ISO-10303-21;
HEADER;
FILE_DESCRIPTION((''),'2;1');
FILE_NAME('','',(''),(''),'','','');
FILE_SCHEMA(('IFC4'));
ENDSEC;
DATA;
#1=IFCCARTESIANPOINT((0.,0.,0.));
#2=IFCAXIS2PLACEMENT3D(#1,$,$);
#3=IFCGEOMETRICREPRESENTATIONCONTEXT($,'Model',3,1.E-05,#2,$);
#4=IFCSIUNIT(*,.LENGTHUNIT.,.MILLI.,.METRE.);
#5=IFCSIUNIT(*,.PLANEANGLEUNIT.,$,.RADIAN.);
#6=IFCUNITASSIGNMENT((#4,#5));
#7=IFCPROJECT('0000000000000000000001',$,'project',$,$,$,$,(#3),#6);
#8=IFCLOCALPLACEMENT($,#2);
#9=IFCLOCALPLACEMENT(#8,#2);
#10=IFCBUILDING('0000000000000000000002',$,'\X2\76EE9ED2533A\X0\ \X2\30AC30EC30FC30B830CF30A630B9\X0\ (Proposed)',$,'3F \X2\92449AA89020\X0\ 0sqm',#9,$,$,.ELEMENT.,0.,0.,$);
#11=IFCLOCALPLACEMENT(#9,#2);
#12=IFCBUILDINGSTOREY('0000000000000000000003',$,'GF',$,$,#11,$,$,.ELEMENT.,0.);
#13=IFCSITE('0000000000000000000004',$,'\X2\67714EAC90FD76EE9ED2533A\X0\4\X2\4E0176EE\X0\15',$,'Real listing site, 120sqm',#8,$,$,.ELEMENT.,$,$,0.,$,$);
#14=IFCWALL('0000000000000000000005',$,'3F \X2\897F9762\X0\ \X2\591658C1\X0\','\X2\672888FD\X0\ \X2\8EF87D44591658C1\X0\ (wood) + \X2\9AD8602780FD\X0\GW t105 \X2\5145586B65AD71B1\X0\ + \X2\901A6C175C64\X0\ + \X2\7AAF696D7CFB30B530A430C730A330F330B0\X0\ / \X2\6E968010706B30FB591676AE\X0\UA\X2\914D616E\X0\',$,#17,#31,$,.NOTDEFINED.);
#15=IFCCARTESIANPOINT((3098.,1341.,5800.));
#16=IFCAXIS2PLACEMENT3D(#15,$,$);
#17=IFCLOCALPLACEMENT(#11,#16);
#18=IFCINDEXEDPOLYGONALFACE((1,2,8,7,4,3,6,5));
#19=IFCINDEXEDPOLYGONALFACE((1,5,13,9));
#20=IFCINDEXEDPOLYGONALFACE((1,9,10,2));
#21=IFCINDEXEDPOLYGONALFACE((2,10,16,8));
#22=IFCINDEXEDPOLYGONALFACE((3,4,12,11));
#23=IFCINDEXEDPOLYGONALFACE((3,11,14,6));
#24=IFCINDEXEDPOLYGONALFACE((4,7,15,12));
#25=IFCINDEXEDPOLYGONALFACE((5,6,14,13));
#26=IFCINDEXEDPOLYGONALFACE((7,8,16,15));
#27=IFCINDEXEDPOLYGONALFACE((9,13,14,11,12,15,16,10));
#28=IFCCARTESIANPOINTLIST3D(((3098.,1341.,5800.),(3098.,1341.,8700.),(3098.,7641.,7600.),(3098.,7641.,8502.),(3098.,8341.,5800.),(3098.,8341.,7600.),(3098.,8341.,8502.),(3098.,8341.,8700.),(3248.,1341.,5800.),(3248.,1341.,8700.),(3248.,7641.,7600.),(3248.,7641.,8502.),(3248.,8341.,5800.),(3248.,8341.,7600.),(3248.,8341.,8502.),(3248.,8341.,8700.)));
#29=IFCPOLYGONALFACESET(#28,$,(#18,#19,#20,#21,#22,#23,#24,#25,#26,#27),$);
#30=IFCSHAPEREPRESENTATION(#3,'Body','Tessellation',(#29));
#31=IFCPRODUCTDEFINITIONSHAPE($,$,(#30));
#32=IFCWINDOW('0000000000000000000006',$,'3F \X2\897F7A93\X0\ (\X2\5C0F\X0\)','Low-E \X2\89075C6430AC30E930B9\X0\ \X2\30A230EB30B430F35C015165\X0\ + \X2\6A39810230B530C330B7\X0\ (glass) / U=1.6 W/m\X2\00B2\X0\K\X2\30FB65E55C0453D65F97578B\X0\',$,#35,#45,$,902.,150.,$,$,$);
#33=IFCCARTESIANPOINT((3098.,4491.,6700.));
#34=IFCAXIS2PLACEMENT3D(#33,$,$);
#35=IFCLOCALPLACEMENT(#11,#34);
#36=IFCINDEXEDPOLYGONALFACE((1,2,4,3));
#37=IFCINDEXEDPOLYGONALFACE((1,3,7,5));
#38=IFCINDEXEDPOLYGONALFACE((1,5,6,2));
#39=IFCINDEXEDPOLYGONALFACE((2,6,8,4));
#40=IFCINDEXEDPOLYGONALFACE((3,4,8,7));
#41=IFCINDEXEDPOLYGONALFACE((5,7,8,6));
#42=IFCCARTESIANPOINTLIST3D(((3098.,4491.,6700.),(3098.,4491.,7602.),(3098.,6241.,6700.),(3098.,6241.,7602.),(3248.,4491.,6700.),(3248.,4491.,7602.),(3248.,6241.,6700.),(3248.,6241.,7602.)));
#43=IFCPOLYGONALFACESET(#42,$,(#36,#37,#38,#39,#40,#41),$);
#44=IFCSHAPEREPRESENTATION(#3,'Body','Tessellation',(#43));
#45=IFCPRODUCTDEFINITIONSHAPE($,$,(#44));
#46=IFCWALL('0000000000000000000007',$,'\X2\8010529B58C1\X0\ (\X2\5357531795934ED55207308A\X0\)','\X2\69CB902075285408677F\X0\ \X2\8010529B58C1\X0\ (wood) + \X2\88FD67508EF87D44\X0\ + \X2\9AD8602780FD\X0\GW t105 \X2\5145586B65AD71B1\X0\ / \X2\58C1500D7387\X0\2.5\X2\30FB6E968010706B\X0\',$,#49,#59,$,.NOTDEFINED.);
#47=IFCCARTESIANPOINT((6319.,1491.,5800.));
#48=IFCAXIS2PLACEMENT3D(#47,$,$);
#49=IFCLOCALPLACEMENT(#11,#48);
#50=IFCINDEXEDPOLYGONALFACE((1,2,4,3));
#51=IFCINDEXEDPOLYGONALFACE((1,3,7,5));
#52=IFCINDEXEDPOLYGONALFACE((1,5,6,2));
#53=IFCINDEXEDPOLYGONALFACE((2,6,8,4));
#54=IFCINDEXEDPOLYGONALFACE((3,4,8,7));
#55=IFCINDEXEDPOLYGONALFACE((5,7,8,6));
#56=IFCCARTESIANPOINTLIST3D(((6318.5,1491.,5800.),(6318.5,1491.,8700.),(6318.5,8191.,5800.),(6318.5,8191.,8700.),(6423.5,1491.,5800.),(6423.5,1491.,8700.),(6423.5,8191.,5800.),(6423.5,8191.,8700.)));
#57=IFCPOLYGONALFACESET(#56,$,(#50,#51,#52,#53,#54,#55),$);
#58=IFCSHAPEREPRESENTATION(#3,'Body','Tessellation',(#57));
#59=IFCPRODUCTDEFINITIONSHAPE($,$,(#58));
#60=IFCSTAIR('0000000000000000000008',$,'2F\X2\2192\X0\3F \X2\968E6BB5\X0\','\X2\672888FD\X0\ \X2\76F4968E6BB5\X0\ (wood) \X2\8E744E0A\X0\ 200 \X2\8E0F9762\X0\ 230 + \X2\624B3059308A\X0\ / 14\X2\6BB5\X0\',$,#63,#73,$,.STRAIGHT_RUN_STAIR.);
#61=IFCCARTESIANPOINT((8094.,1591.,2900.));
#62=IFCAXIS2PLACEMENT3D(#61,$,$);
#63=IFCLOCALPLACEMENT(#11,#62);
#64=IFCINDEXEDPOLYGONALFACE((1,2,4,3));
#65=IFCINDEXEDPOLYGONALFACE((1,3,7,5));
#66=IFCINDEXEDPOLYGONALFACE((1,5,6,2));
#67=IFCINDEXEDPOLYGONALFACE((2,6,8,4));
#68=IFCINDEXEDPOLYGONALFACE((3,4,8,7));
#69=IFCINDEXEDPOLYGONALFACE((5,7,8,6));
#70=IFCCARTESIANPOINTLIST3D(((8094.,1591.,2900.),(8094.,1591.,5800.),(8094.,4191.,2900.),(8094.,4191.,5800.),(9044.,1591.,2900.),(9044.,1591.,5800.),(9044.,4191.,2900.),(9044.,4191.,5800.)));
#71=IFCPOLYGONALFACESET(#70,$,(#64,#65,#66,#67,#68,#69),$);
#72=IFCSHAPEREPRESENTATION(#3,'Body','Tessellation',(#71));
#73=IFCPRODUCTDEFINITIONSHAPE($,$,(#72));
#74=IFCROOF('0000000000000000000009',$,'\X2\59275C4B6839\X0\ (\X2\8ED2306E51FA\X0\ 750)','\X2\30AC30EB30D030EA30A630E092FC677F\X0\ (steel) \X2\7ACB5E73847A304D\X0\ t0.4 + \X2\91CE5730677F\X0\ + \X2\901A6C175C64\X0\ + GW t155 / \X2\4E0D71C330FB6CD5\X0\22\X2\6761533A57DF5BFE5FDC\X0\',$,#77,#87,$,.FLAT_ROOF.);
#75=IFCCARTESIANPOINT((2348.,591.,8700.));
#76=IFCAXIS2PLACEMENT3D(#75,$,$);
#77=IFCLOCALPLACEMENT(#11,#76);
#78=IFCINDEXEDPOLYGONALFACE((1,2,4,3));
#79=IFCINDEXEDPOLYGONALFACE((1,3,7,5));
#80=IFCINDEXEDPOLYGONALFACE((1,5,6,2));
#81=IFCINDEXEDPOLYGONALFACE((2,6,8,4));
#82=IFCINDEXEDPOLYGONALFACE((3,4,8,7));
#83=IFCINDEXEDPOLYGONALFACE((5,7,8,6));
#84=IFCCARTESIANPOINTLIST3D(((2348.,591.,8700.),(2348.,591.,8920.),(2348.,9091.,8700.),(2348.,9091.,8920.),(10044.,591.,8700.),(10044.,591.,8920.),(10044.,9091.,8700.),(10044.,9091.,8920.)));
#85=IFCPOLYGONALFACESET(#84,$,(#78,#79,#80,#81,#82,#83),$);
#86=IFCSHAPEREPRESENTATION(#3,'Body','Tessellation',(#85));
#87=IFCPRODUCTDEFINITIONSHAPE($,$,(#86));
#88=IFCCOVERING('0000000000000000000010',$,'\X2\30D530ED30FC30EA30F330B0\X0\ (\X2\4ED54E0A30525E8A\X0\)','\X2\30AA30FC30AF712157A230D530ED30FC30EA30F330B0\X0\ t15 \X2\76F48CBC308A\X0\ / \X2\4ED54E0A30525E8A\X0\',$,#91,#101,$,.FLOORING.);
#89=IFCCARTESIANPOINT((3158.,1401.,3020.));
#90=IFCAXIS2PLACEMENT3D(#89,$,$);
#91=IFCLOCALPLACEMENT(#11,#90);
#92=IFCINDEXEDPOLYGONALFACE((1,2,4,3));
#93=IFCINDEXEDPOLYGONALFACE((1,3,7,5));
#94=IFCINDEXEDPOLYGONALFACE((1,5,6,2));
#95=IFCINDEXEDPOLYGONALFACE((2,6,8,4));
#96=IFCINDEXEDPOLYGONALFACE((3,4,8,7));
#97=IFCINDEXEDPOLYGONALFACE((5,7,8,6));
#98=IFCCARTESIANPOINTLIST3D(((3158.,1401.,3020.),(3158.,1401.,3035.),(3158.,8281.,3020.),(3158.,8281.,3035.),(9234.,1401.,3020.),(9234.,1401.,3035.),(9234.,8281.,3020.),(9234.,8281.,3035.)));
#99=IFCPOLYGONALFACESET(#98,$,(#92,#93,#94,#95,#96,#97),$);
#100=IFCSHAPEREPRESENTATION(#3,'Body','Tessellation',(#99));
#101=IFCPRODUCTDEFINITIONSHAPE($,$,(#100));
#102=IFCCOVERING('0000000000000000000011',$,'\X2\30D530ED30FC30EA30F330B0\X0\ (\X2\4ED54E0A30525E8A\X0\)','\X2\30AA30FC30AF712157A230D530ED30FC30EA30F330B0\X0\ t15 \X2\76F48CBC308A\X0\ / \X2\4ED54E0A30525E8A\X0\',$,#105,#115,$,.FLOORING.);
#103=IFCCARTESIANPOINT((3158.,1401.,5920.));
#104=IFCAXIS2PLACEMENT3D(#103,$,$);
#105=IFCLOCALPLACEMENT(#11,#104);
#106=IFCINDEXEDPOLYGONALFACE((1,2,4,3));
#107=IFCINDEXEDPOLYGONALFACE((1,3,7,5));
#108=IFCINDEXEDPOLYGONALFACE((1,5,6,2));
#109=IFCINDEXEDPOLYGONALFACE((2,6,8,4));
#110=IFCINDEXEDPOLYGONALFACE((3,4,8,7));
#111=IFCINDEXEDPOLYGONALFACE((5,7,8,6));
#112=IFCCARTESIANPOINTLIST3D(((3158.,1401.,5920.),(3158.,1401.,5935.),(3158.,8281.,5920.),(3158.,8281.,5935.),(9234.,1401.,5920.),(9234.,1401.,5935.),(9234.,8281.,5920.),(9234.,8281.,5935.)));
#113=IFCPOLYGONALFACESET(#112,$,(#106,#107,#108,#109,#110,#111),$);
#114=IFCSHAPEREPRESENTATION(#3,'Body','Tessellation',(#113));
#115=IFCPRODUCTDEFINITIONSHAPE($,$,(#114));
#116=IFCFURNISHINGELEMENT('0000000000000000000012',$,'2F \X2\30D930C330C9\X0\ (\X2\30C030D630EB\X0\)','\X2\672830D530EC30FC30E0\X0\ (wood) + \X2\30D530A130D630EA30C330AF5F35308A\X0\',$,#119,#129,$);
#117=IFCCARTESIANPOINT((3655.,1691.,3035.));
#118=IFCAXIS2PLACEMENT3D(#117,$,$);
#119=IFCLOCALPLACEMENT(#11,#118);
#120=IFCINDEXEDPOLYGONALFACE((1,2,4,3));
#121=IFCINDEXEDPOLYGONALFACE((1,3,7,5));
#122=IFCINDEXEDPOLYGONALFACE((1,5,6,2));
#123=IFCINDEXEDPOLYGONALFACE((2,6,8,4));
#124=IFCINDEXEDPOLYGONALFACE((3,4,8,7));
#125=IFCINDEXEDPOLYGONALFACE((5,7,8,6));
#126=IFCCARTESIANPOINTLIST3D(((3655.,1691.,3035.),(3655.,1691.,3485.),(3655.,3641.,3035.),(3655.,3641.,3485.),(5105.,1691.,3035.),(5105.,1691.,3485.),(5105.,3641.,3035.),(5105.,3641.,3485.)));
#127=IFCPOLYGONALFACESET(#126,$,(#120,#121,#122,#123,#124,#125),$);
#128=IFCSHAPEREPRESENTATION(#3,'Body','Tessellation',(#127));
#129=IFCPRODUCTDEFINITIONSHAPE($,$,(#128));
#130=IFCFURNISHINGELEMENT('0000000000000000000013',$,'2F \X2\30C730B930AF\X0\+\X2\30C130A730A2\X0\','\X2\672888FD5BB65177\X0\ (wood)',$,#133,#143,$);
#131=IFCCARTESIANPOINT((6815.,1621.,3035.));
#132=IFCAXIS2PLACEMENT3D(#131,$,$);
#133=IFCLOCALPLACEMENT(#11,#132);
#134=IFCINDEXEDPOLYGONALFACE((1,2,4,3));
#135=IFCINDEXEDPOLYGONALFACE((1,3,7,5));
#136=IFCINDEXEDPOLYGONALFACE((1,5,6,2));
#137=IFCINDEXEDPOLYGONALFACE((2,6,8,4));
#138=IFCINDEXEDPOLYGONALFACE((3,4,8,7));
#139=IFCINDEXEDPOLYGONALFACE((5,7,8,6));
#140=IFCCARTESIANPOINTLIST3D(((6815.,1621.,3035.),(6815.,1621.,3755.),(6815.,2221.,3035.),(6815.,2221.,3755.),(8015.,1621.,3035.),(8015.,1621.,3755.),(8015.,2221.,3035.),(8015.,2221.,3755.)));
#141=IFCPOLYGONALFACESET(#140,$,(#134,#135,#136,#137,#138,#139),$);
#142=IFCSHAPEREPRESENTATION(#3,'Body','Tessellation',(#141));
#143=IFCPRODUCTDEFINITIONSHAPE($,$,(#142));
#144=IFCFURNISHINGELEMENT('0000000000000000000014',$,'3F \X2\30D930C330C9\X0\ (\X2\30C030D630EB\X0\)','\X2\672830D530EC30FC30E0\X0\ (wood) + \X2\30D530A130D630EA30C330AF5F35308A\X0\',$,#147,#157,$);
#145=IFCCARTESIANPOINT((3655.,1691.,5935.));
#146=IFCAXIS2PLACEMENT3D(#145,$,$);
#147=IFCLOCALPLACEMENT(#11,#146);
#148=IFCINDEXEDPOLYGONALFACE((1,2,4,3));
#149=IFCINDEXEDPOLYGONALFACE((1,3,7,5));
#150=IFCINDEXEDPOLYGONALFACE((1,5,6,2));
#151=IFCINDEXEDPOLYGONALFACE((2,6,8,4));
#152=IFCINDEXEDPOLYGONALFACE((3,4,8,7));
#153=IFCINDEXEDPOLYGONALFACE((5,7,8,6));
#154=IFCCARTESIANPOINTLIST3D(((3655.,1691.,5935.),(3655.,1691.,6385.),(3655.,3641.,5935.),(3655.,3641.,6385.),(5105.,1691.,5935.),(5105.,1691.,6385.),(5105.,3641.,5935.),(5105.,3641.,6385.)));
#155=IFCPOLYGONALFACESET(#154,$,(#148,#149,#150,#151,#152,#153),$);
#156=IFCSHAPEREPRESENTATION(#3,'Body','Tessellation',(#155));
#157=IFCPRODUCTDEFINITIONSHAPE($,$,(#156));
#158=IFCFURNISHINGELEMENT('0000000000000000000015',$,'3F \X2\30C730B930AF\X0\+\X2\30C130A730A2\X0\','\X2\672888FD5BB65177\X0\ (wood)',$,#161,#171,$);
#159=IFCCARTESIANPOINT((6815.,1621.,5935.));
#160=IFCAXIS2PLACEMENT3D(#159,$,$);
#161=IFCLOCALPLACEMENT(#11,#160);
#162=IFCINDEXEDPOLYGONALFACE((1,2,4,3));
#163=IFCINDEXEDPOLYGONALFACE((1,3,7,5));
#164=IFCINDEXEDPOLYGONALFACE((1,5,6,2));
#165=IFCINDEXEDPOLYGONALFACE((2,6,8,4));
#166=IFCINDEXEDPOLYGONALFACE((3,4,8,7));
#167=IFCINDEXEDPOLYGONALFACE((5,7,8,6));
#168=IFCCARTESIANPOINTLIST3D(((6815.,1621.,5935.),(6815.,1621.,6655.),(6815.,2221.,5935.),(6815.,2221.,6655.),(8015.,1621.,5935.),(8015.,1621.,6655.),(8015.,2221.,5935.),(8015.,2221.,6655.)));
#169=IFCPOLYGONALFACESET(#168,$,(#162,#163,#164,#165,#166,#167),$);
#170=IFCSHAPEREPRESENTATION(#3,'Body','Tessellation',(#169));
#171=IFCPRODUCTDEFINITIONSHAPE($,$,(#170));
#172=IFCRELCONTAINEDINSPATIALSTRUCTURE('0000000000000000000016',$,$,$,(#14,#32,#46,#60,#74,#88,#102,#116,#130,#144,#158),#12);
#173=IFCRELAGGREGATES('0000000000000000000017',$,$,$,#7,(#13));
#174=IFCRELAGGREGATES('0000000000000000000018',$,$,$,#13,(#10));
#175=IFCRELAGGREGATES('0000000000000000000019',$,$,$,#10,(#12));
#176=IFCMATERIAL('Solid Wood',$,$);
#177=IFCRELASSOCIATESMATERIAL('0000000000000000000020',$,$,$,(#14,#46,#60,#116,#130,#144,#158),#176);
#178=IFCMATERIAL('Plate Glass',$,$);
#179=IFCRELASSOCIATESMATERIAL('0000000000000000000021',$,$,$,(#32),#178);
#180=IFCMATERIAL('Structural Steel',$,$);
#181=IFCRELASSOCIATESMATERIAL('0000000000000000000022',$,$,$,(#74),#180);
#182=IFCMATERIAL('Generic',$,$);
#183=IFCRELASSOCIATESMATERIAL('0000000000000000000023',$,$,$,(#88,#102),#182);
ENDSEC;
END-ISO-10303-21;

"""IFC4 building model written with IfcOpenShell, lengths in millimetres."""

from ifc_helpers import new_model, si_unit, frame, frame_2d, origin, place, context, project, spatial, rectangle, extrude, material, element, fill, save


model = new_model("IFC4")

# Units and contexts
model_context = context("Model", 3, precision=1e-05, world=origin())
ifc_project = project(units=[si_unit("LENGTHUNIT", "METRE", prefix="MILLI"), si_unit("PLANEANGLEUNIT", "RADIAN")], contexts=[model_context])

# Site, building, storey
site_placement = place(None, origin())
site = spatial("IfcSite", under=ifc_project, at=site_placement, Name="東京都目黒区4丁目15", ObjectType="Real listing site, 120sqm", CompositionType="ELEMENT", RefElevation=0.0)
building_placement = place(site_placement, origin())
building = spatial("IfcBuilding", under=site, at=building_placement, Name="目黒区 ガレージハウス (Proposed)", ObjectType="3F 鉄骨造 0sqm", CompositionType="ELEMENT", ElevationOfRefHeight=0.0, ElevationOfTerrain=0.0)
storey_placement = place(building_placement, origin())
storey = spatial("IfcBuildingStorey", under=building, at=storey_placement, Name="GF", CompositionType="ELEMENT", Elevation=0.0)

# Shared definitions
ifc_material_1 = material(Name="Solid Wood")

# Shared definitions
ifc_material_2 = material(Name="Plate Glass")

# Wall, opening, window
wall_1_placement = place(storey_placement, frame((3098.0, 1341.0, 5800.0)))
wall_1 = element("IfcWall", 1, at=wall_1_placement, inside=storey, material=ifc_material_1, Name="3F 西面 外壁", Description="木製 軸組外壁 (wood) + 高性能GW t105 充填断熱 + 通気層 + 窯業系サイディング / 準耐火・外皮UA配慮", PredefinedType="NOTDEFINED", context=model_context, shape_type="SweptSolid", body=[
    extrude(rectangle(XDim=150.0, YDim=7000.0, at=frame_2d((75.0, 3500.0))), frame((3098.0, 1341.0, 5800.0)), (0.0, 0.0, 1.0), 2900.0),
])
opening_1_placement = place(storey_placement, frame((3098.0, 4491.0, 6700.0)))
opening_1 = element("IfcOpeningElement", 2, at=opening_1_placement, cuts=wall_1, PredefinedType="NOTDEFINED", context=model_context, shape_type="SweptSolid", body=[
    extrude(rectangle(XDim=150.0, YDim=1750.0, at=frame_2d((75.0, 875.0))), frame((3098.0, 4491.0, 6700.0)), (0.0, 0.0, 1.0), 902.0),
])
window_1_placement = place(storey_placement, frame((3098.0, 4491.0, 6700.0)))
window_1 = element("IfcWindow", 3, at=window_1_placement, inside=storey, material=ifc_material_2, Name="3F 西窓 (小)", Description="Low-E 複層ガラス アルゴン封入 + 樹脂サッシ (glass) / U=1.6 W/m²K・日射取得型", OverallHeight=902.0, OverallWidth=150.0, context=model_context, shape_type="SweptSolid", body=[
    extrude(rectangle(XDim=150.0, YDim=1750.0, at=frame_2d((75.0, 875.0))), frame((3098.0, 4491.0, 6700.0)), (0.0, 0.0, 1.0), 902.0),
])
fill(opening_1, window_1)

# Wall
wall_2_placement = place(storey_placement, frame((6319.0, 1491.0, 5800.0)))
element("IfcWall", 4, at=wall_2_placement, inside=storey, material=ifc_material_1, Name="耐力壁 (南北間仕切り)", Description="構造用合板 耐力壁 (wood) + 製材軸組 + 高性能GW t105 充填断熱 / 壁倍率2.5・準耐火", PredefinedType="NOTDEFINED", context=model_context, shape_type="SweptSolid", body=[
    extrude(rectangle(XDim=105.0, YDim=6700.0, at=frame_2d((52.0, 3350.0))), frame((6319.0, 1491.0, 5800.0)), (0.0, 0.0, 1.0), 2900.0),
])

# Stair
stair_placement = place(storey_placement, frame((8094.0, 1591.0, 2900.0)))
element("IfcStair", 5, at=stair_placement, inside=storey, material=ifc_material_1, Name="2F→3F 階段", Description="木製 直階段 (wood) 蹴上 200 踏面 230 + 手すり / 14段", PredefinedType="STRAIGHT_RUN_STAIR", context=model_context, shape_type="SweptSolid", body=[
    extrude(rectangle(XDim=950.0, YDim=2600.0, at=frame_2d((475.0, 1300.0))), frame((8094.0, 1591.0, 2900.0)), (0.0, 0.0, 1.0), 2900.0),
])

# Roof
ifc_material_3 = material(Name="Structural Steel")
roof_placement = place(storey_placement, frame((2348.0, 591.0, 8700.0)))
element("IfcRoof", 6, at=roof_placement, inside=storey, material=ifc_material_3, Name="大屋根 (軒の出 750)", Description="ガルバリウム鋼板 (steel) 立平葺き t0.4 + 野地板 + 通気層 + GW t155 / 不燃・法22条区域対応", PredefinedType="FLAT_ROOF", context=model_context, shape_type="SweptSolid", body=[
    extrude(rectangle(XDim=7696.0, YDim=8500.0, at=frame_2d((3848.0, 4250.0))), frame((2348.0, 591.0, 8700.0)), (0.0, 0.0, 1.0), 220.0),
])

# Coverings
ifc_material_4 = material(Name="Generic")
covering_1_placement = place(storey_placement, frame((3158.0, 1401.0, 3020.0)))
element("IfcCovering", 7, at=covering_1_placement, inside=storey, material=ifc_material_4, Name="フローリング (仕上げ床)", Description="オーク無垢フローリング t15 直貼り / 仕上げ床", PredefinedType="FLOORING", context=model_context, shape_type="SweptSolid", body=[
    extrude(rectangle(XDim=6076.0, YDim=6880.0, at=frame_2d((3038.0, 3440.0))), frame((3158.0, 1401.0, 3020.0)), (0.0, 0.0, 1.0), 15.0),
])
covering_2_placement = place(storey_placement, frame((3158.0, 1401.0, 5920.0)))
element("IfcCovering", 8, at=covering_2_placement, inside=storey, material=ifc_material_4, Name="フローリング (仕上げ床)", Description="オーク無垢フローリング t15 直貼り / 仕上げ床", PredefinedType="FLOORING", context=model_context, shape_type="SweptSolid", body=[
    extrude(rectangle(XDim=6076.0, YDim=6880.0, at=frame_2d((3038.0, 3440.0))), frame((3158.0, 1401.0, 5920.0)), (0.0, 0.0, 1.0), 15.0),
])

# Furnishing elements
furnishing_1_placement = place(storey_placement, frame((3655.0, 1691.0, 3035.0)))
element("IfcFurnishingElement", 9, at=furnishing_1_placement, inside=storey, material=ifc_material_1, Name="2F ベッド (ダブル)", Description="木フレーム (wood) + ファブリック張り", context=model_context, shape_type="SweptSolid", body=[
    extrude(rectangle(XDim=1450.0, YDim=1950.0, at=frame_2d((725.0, 975.0))), frame((3655.0, 1691.0, 3035.0)), (0.0, 0.0, 1.0), 450.0),
])
furnishing_2_placement = place(storey_placement, frame((6815.0, 1621.0, 3035.0)))
element("IfcFurnishingElement", 10, at=furnishing_2_placement, inside=storey, material=ifc_material_1, Name="2F デスク+チェア", Description="木製家具 (wood)", context=model_context, shape_type="SweptSolid", body=[
    extrude(rectangle(XDim=1200.0, YDim=600.0, at=frame_2d((600.0, 300.0))), frame((6815.0, 1621.0, 3035.0)), (0.0, 0.0, 1.0), 720.0),
])
furnishing_3_placement = place(storey_placement, frame((3655.0, 1691.0, 5935.0)))
element("IfcFurnishingElement", 11, at=furnishing_3_placement, inside=storey, material=ifc_material_1, Name="3F ベッド (ダブル)", Description="木フレーム (wood) + ファブリック張り", context=model_context, shape_type="SweptSolid", body=[
    extrude(rectangle(XDim=1450.0, YDim=1950.0, at=frame_2d((725.0, 975.0))), frame((3655.0, 1691.0, 5935.0)), (0.0, 0.0, 1.0), 450.0),
])
furnishing_4_placement = place(storey_placement, frame((6815.0, 1621.0, 5935.0)))
element("IfcFurnishingElement", 12, at=furnishing_4_placement, inside=storey, material=ifc_material_1, Name="3F デスク+チェア", Description="木製家具 (wood)", context=model_context, shape_type="SweptSolid", body=[
    extrude(rectangle(XDim=1200.0, YDim=600.0, at=frame_2d((600.0, 300.0))), frame((6815.0, 1621.0, 5935.0)), (0.0, 0.0, 1.0), 720.0),
])

save(model, "model.ifc")
